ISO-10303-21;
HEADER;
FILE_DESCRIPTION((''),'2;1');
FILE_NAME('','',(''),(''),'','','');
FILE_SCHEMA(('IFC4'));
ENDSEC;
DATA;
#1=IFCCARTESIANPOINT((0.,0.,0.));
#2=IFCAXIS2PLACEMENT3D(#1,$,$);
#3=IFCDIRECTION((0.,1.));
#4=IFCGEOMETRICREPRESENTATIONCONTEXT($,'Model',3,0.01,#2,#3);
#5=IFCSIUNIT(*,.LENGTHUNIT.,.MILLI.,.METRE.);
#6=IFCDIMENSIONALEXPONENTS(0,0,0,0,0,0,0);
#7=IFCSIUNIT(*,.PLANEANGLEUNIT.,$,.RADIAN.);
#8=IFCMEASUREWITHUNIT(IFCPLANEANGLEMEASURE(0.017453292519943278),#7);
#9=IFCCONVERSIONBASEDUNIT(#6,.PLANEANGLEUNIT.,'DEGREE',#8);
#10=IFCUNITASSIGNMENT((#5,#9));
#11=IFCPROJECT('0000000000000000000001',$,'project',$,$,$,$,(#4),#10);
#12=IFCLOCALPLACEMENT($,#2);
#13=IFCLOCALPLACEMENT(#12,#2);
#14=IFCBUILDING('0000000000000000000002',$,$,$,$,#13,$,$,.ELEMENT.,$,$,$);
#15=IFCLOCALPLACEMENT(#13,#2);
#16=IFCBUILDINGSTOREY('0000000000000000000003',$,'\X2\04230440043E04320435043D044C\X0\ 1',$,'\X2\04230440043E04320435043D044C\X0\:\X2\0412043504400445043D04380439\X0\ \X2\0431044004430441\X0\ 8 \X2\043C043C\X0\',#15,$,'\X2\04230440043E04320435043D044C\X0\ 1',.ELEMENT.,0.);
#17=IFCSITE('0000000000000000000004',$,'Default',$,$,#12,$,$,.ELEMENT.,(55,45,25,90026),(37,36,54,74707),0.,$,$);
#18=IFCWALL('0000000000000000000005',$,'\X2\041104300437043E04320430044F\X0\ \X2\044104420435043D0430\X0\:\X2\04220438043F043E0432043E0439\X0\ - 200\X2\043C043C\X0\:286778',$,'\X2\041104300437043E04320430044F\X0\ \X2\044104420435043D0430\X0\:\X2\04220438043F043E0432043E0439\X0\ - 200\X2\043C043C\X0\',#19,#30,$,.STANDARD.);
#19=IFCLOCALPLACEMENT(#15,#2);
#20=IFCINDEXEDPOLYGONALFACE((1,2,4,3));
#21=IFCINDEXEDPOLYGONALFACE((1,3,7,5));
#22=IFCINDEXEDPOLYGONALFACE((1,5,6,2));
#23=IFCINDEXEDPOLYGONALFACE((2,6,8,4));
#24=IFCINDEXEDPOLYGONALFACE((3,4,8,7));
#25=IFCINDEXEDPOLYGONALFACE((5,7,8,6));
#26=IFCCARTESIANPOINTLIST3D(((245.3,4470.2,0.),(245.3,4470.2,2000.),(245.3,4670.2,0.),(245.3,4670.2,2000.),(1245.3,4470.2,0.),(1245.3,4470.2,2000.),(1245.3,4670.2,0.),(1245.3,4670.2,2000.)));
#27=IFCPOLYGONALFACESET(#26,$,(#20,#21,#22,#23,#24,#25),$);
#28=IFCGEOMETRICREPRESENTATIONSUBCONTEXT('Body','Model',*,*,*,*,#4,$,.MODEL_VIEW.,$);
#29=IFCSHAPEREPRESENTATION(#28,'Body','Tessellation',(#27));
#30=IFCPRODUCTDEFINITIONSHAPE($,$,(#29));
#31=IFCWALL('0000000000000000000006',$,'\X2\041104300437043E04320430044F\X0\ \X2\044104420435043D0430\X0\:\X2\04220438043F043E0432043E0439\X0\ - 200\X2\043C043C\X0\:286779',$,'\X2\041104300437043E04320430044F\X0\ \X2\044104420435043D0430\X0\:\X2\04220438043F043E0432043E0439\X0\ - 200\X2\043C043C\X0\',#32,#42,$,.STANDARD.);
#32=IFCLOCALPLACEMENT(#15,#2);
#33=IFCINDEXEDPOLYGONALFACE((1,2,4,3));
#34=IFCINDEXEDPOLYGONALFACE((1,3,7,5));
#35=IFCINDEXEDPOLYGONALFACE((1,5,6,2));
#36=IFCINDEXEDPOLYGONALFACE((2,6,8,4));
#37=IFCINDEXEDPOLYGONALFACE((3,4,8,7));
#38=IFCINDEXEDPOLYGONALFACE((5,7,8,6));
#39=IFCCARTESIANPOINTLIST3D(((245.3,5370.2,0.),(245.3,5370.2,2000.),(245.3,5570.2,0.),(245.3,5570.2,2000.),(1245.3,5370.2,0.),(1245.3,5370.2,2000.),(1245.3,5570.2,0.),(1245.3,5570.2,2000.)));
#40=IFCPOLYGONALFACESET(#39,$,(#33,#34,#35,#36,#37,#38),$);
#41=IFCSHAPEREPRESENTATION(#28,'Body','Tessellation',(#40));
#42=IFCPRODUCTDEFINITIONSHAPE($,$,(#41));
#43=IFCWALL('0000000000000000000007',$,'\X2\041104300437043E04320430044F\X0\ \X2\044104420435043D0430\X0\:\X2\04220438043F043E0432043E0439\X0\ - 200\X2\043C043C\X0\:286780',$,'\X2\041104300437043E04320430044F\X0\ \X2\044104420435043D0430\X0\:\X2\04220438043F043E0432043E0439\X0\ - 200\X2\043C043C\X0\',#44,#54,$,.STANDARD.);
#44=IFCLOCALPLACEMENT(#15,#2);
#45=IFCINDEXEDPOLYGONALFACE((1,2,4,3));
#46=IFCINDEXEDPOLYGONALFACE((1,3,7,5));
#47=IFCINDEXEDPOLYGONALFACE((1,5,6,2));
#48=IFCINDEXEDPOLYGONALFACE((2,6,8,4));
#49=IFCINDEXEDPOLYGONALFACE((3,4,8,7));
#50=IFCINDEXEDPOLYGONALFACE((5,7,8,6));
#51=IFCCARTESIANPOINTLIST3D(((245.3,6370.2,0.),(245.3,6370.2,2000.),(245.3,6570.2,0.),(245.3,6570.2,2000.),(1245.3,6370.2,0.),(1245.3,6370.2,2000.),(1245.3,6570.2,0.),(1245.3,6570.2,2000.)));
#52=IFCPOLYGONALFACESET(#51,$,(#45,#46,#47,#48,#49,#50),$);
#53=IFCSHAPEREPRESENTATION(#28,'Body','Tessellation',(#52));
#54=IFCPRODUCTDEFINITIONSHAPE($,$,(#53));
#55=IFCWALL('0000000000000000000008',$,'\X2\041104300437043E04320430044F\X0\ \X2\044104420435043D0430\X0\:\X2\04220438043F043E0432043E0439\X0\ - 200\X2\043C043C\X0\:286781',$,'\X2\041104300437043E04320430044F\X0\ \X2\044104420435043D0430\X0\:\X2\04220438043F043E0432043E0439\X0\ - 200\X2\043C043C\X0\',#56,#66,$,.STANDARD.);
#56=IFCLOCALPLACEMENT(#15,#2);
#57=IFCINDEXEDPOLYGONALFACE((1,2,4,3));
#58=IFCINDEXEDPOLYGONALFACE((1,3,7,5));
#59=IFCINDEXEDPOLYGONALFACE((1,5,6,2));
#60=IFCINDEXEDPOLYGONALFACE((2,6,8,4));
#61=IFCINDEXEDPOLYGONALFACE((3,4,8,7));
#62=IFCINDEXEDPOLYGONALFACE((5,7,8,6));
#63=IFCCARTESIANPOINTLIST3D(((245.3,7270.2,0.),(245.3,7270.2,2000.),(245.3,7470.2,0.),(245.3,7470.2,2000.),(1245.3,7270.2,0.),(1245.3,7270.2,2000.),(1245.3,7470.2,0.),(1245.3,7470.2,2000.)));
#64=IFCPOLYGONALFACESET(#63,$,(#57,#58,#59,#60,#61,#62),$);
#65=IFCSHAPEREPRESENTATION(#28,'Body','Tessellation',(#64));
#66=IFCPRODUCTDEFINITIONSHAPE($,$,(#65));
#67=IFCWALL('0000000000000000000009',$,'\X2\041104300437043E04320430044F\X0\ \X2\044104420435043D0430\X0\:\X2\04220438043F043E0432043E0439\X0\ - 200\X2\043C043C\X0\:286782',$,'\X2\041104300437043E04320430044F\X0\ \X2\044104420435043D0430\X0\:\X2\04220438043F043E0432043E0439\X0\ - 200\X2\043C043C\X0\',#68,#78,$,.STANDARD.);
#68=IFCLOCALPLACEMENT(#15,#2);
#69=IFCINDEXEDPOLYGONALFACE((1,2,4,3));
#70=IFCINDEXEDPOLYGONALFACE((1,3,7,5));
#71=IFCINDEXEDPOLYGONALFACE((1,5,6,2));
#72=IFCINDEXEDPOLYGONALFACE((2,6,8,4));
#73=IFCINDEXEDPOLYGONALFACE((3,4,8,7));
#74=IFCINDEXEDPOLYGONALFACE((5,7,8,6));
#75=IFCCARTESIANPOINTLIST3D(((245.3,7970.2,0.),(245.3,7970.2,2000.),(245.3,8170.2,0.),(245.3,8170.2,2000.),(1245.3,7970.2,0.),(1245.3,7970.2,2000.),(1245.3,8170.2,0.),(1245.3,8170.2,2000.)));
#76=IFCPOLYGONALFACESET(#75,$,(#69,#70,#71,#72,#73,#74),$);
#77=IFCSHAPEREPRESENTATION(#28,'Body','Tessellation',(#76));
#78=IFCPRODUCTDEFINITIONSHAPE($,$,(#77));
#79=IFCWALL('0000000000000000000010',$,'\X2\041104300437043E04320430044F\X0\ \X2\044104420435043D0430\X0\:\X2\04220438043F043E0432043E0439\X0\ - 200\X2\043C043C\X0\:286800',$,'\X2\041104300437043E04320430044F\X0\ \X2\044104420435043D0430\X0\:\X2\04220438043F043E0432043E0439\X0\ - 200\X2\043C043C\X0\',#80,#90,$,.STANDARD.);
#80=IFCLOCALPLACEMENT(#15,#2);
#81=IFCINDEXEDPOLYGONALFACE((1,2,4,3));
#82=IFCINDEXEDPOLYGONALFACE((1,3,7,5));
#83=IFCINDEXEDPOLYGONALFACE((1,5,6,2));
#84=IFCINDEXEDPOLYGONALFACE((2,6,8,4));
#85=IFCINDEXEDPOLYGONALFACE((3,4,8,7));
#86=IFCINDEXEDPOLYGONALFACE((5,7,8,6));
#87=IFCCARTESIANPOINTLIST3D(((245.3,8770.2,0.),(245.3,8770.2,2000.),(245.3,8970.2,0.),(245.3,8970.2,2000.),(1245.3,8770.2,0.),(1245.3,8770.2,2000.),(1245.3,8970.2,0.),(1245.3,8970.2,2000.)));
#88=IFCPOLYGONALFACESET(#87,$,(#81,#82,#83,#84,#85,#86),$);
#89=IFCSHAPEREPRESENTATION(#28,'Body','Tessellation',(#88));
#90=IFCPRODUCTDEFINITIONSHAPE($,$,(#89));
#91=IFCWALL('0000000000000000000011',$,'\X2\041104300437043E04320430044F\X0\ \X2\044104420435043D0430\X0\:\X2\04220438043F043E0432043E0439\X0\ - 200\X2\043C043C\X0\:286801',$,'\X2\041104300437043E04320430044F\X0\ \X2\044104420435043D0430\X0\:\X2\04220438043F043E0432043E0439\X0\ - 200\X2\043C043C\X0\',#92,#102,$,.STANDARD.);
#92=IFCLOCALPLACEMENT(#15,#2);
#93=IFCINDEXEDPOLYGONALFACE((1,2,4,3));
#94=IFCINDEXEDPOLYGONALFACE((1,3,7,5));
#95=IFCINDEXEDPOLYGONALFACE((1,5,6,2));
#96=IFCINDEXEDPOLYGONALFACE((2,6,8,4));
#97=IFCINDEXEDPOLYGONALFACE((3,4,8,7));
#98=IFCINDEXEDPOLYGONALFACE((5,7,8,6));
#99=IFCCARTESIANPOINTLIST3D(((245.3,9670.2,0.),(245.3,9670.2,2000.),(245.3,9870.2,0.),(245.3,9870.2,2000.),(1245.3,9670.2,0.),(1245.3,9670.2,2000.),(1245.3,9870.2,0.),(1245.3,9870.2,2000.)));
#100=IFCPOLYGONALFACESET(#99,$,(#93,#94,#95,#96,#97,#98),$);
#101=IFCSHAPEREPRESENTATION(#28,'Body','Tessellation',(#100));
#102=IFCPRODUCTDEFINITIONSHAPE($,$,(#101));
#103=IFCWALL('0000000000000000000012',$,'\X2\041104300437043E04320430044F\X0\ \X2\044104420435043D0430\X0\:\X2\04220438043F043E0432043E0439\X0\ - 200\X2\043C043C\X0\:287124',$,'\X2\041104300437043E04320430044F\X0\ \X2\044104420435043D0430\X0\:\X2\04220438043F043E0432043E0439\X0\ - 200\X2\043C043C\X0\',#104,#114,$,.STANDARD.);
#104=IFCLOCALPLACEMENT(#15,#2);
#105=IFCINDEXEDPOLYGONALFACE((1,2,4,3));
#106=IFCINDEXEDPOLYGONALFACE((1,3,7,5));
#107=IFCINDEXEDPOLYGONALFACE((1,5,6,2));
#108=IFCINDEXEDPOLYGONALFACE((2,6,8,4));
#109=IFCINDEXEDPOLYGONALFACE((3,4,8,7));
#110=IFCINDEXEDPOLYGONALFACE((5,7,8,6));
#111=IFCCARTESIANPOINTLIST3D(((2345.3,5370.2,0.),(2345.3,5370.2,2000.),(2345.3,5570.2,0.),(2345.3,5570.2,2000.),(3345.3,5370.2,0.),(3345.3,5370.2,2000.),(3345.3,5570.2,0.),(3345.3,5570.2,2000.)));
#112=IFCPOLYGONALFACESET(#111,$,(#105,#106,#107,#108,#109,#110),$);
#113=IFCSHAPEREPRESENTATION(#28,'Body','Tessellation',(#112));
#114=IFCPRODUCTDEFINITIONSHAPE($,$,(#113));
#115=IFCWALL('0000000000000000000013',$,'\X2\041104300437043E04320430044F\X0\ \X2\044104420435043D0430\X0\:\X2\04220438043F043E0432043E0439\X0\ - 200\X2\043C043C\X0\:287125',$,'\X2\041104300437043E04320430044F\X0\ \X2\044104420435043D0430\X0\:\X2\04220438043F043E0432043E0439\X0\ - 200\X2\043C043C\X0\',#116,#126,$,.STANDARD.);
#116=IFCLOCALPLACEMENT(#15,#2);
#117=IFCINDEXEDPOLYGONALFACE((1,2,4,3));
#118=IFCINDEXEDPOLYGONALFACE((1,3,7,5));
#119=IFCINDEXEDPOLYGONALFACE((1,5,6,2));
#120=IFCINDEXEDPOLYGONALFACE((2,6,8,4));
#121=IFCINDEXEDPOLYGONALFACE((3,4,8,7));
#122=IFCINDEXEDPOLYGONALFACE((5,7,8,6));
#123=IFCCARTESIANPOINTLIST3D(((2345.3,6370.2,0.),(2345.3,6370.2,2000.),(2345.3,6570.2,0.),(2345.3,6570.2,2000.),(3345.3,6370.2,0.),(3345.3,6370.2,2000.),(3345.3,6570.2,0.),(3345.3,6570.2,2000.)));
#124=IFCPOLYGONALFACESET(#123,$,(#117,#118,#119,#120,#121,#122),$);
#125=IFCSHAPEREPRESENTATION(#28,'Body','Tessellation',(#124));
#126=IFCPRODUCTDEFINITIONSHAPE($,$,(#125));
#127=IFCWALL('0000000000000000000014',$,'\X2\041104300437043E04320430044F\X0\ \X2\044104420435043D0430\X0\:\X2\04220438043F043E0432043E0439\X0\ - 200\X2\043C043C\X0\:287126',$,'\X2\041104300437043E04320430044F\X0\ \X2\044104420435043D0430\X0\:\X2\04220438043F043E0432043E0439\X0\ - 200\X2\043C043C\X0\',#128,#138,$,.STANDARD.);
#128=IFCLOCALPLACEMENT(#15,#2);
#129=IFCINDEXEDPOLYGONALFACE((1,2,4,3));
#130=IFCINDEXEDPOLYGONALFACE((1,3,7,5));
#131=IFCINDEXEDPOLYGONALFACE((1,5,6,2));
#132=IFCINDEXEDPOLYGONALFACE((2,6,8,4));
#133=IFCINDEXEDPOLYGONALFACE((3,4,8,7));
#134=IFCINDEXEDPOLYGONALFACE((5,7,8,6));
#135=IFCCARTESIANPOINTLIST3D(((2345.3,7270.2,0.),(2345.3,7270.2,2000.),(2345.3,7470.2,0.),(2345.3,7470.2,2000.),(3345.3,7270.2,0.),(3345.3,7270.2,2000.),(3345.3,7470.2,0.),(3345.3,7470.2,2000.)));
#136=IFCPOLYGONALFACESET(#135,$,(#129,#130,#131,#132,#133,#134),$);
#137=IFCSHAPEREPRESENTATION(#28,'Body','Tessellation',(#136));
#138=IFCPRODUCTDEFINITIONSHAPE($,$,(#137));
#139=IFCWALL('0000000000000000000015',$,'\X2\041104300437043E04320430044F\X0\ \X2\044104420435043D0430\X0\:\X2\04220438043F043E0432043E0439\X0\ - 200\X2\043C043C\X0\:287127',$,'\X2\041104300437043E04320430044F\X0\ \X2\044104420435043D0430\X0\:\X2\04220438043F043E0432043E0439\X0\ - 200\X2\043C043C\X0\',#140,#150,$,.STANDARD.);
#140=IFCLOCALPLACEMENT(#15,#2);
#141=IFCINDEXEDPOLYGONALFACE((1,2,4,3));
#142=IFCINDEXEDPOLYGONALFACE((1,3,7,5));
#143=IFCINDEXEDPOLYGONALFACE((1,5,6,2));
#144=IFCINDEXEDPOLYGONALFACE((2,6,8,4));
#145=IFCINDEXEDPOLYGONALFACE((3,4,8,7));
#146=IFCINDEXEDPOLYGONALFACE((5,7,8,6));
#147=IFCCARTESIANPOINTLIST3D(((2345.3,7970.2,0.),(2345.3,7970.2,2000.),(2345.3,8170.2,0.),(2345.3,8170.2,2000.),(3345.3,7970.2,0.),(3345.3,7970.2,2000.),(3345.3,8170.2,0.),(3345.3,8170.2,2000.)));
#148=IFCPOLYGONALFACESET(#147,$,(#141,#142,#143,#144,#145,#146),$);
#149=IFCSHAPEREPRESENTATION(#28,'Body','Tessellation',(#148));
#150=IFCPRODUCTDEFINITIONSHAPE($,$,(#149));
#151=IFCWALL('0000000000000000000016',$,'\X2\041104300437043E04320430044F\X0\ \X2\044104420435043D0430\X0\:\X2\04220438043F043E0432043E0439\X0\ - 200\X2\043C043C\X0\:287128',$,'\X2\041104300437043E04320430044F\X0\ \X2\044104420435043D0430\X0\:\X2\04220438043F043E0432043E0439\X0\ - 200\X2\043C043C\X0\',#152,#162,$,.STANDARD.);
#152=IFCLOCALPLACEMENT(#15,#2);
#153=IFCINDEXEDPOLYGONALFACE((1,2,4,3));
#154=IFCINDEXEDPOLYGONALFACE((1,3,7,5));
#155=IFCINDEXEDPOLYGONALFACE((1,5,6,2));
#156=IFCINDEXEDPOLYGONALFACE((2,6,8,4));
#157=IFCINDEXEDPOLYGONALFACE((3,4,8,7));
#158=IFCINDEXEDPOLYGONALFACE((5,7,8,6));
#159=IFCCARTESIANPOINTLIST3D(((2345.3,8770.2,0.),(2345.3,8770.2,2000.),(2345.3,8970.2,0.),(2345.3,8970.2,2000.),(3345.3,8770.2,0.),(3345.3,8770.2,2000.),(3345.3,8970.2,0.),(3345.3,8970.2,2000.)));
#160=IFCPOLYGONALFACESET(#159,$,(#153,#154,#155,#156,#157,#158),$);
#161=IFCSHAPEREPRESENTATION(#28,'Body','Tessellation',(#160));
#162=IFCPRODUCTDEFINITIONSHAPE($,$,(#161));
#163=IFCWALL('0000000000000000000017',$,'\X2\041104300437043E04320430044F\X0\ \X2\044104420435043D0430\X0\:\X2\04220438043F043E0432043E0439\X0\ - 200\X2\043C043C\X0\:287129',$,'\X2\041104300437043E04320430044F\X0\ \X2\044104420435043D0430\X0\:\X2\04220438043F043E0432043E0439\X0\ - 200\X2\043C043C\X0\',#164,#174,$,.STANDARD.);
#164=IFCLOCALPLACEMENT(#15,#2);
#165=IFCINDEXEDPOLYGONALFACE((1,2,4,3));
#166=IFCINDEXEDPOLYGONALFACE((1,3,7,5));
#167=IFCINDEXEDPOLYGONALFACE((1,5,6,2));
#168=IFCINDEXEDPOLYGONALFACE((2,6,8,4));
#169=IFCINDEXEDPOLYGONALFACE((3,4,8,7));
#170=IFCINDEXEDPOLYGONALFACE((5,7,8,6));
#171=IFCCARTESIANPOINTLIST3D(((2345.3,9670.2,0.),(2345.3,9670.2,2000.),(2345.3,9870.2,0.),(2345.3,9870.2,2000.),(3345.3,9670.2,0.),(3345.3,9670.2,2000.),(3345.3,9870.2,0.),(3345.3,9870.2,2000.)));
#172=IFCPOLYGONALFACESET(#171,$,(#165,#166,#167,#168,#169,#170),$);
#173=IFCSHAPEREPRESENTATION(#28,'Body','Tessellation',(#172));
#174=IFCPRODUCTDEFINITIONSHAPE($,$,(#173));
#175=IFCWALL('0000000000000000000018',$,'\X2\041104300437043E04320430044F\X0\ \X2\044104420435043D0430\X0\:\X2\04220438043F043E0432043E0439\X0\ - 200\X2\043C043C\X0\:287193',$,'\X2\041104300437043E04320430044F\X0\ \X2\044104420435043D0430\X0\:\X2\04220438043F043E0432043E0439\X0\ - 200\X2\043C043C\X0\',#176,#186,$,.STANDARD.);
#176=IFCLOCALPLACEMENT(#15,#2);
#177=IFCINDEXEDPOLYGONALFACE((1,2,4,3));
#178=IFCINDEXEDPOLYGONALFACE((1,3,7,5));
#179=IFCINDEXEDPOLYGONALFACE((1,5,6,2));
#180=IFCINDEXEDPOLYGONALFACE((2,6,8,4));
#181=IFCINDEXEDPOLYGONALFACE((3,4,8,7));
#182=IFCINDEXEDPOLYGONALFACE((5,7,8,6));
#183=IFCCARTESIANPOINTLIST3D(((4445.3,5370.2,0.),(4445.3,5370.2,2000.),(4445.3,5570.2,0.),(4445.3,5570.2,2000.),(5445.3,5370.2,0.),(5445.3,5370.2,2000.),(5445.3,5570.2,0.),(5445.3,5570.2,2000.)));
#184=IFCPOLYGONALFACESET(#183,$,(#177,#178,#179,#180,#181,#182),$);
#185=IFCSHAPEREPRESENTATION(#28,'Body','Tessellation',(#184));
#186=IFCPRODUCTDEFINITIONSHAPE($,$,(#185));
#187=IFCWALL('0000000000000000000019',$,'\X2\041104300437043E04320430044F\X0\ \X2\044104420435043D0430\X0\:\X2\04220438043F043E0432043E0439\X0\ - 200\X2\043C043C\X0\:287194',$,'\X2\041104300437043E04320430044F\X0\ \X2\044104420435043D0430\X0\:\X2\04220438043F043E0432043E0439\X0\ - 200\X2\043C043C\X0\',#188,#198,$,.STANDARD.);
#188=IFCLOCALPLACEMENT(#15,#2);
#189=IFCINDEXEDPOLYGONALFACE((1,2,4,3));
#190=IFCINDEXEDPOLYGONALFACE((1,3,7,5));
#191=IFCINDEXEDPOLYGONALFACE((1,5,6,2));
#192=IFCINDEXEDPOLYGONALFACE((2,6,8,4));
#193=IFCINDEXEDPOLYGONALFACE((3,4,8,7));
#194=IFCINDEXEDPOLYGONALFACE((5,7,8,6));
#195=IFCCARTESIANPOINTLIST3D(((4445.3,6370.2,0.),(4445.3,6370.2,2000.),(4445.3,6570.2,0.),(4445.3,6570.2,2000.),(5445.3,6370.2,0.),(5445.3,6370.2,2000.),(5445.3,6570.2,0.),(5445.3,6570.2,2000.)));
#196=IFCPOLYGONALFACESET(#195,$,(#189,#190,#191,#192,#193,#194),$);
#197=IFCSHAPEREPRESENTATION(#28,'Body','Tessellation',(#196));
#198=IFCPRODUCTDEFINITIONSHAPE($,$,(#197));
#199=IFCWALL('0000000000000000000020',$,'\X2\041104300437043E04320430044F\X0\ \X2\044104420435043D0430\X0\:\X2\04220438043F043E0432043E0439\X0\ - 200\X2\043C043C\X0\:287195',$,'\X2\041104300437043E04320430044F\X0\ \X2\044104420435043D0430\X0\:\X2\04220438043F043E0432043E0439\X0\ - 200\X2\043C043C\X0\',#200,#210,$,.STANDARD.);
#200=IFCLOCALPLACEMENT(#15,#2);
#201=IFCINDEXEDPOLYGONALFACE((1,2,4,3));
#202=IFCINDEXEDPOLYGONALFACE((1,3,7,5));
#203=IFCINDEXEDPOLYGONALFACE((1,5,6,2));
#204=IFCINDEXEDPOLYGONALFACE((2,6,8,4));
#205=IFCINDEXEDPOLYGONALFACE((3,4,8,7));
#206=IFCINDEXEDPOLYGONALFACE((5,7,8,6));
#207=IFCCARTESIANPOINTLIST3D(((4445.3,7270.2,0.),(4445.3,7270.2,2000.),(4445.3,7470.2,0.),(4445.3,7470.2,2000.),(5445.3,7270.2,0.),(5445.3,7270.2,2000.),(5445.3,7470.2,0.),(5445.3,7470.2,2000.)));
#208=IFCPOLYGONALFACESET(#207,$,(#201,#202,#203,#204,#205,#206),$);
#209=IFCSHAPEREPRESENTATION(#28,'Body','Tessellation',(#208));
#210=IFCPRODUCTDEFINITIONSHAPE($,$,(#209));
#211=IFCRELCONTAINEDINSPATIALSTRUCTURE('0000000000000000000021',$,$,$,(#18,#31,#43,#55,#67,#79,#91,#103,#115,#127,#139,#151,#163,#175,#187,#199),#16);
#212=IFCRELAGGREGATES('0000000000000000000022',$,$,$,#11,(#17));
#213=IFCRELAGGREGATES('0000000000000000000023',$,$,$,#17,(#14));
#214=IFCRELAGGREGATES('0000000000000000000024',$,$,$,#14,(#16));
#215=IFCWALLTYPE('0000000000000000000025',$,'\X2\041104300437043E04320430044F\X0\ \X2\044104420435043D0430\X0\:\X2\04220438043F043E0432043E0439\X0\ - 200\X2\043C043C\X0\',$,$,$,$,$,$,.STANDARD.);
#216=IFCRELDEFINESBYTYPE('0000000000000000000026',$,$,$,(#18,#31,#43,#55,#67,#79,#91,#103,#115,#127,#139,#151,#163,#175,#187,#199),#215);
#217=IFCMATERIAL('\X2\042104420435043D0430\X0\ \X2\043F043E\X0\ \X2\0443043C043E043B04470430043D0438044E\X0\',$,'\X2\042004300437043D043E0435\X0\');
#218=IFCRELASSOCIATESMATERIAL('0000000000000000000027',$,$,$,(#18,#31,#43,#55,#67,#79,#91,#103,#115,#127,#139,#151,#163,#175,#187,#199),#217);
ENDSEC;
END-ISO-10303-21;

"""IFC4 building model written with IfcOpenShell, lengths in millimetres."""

from ifc_helpers import new_model, entity, si_unit, converted_unit, direction, frame, origin, place, context, subcontext, project, spatial, indexed_curve, outline, extrude, material, type_object, element, save


model = new_model("IFC4")

# Units and contexts
model_context = context("Model", 3, precision=0.01, world=origin(), true_north=direction((0.0, 1.0)))
body_context = subcontext(model_context, "Body", "Model", "MODEL_VIEW")
ifc_project = project(units=[si_unit("LENGTHUNIT", "METRE", prefix="MILLI"), converted_unit("PLANEANGLEUNIT", "DEGREE", entity("IfcPlaneAngleMeasure", 0.017453292519943278), si_unit("PLANEANGLEUNIT", "RADIAN"), dimensions=[0, 0, 0, 0, 0, 0, 0])], contexts=[model_context])

# Site, building, storey
site_placement = place(None, origin())
site = spatial("IfcSite", under=ifc_project, at=site_placement, Name="Default", CompositionType="ELEMENT", RefLatitude=(55, 45, 25, 90026), RefLongitude=(37, 36, 54, 74707), RefElevation=0.0)
building_placement = place(site_placement, origin())
building = spatial("IfcBuilding", under=site, at=building_placement, CompositionType="ELEMENT")
storey_placement = place(building_placement, origin())
storey = spatial("IfcBuildingStorey", under=building, at=storey_placement, Name="Уровень 1", ObjectType="Уровень:Верхний брус 8 мм", LongName="Уровень 1", CompositionType="ELEMENT", Elevation=0.0)

# Walls
ifc_material = material(Name="Стена по умолчанию", Category="Разное")
wall_type = type_object("IfcWallType", Name="Базовая стена:Типовой - 200мм", PredefinedType="STANDARD")
for number, where, name in (
    (1, (245.3, 4570.2, 0.0), "Базовая стена:Типовой - 200мм:286778"),
    (2, (245.3, 5470.2, 0.0), "Базовая стена:Типовой - 200мм:286779"),
    (3, (245.3, 6470.2, 0.0), "Базовая стена:Типовой - 200мм:286780"),
):
    element("IfcWall", number, at=place(storey_placement, frame(where)), inside=storey, type_object=wall_type, material=ifc_material, Name=name, ObjectType="Базовая стена:Типовой - 200мм", PredefinedType="STANDARD", context=body_context, shape_type="SweptSolid", body=[
        extrude(outline(indexed_curve([(1000.0, 100.0), (0.0, 100.0), (0.0, -100.0), (1000.0, -100.0), (1000.0, 100.0)], self_intersect=False)), origin(), (0.0, 0.0, 1.0), 2000.0),
    ])
for number, where, name in (
    (4, (245.3, 7370.2, 0.0), "Базовая стена:Типовой - 200мм:286781"),
    (5, (245.3, 8070.2, 0.0), "Базовая стена:Типовой - 200мм:286782"),
):
    element("IfcWall", number, at=place(storey_placement, frame(where)), inside=storey, type_object=wall_type, material=ifc_material, Name=name, ObjectType="Базовая стена:Типовой - 200мм", PredefinedType="STANDARD", context=body_context, shape_type="SweptSolid", body=[
        extrude(outline(indexed_curve([(1000.0, 100.0), (0.0, 100.0), (0.0, -100.0), (1000.0, -100.0), (1000.0, 100.0)], self_intersect=False)), origin(), (0.0, 0.0, 1.0), 2000.0),
    ])
wall_1_placement = place(storey_placement, frame((245.3, 8870.2, 0.0)))
element("IfcWall", 6, at=wall_1_placement, inside=storey, type_object=wall_type, material=ifc_material, Name="Базовая стена:Типовой - 200мм:286800", ObjectType="Базовая стена:Типовой - 200мм", PredefinedType="STANDARD", context=body_context, shape_type="SweptSolid", body=[
    extrude(outline(indexed_curve([(1000.0, 100.0), (0.0, 100.0), (0.0, -100.0), (1000.0, -100.0), (1000.0, 100.0)], self_intersect=False)), origin(), (0.0, 0.0, 1.0), 2000.0),
])
wall_2_placement = place(storey_placement, frame((245.3, 9770.2, 0.0)))
element("IfcWall", 7, at=wall_2_placement, inside=storey, type_object=wall_type, material=ifc_material, Name="Базовая стена:Типовой - 200мм:286801", ObjectType="Базовая стена:Типовой - 200мм", PredefinedType="STANDARD", context=body_context, shape_type="SweptSolid", body=[
    extrude(outline(indexed_curve([(1000.0, 100.0), (0.0, 100.0), (0.0, -100.0), (1000.0, -100.0), (1000.0, 100.0)], self_intersect=False)), origin(), (0.0, 0.0, 1.0), 2000.0),
])
for number, where, name in (
    (8, (2345.3, 5470.2, 0.0), "Базовая стена:Типовой - 200мм:287124"),
    (9, (2345.3, 6470.2, 0.0), "Базовая стена:Типовой - 200мм:287125"),
):
    element("IfcWall", number, at=place(storey_placement, frame(where)), inside=storey, type_object=wall_type, material=ifc_material, Name=name, ObjectType="Базовая стена:Типовой - 200мм", PredefinedType="STANDARD", context=body_context, shape_type="SweptSolid", body=[
        extrude(outline(indexed_curve([(1000.0, 100.0), (0.0, 100.0), (0.0, -100.0), (1000.0, -100.0), (1000.0, 100.0)], self_intersect=False)), origin(), (0.0, 0.0, 1.0), 2000.0),
    ])
for number, where, name in (
    (10, (2345.3, 7370.2, 0.0), "Базовая стена:Типовой - 200мм:287126"),
    (11, (2345.3, 8070.2, 0.0), "Базовая стена:Типовой - 200мм:287127"),
):
    element("IfcWall", number, at=place(storey_placement, frame(where)), inside=storey, type_object=wall_type, material=ifc_material, Name=name, ObjectType="Базовая стена:Типовой - 200мм", PredefinedType="STANDARD", context=body_context, shape_type="SweptSolid", body=[
        extrude(outline(indexed_curve([(1000.0, 100.0), (0.0, 100.0), (0.0, -100.0), (1000.0, -100.0), (1000.0, 100.0)], self_intersect=False)), origin(), (0.0, 0.0, 1.0), 2000.0),
    ])
wall_3_placement = place(storey_placement, frame((2345.3, 8870.2, 0.0)))
element("IfcWall", 12, at=wall_3_placement, inside=storey, type_object=wall_type, material=ifc_material, Name="Базовая стена:Типовой - 200мм:287128", ObjectType="Базовая стена:Типовой - 200мм", PredefinedType="STANDARD", context=body_context, shape_type="SweptSolid", body=[
    extrude(outline(indexed_curve([(1000.0, 100.0), (0.0, 100.0), (0.0, -100.0), (1000.0, -100.0), (1000.0, 100.0)], self_intersect=False)), origin(), (0.0, 0.0, 1.0), 2000.0),
])
wall_4_placement = place(storey_placement, frame((2345.3, 9770.2, 0.0)))
element("IfcWall", 13, at=wall_4_placement, inside=storey, type_object=wall_type, material=ifc_material, Name="Базовая стена:Типовой - 200мм:287129", ObjectType="Базовая стена:Типовой - 200мм", PredefinedType="STANDARD", context=body_context, shape_type="SweptSolid", body=[
    extrude(outline(indexed_curve([(1000.0, 100.0), (0.0, 100.0), (0.0, -100.0), (1000.0, -100.0), (1000.0, 100.0)], self_intersect=False)), origin(), (0.0, 0.0, 1.0), 2000.0),
])
for number, where, name in (
    (14, (4445.3, 5470.2, 0.0), "Базовая стена:Типовой - 200мм:287193"),
    (15, (4445.3, 6470.2, 0.0), "Базовая стена:Типовой - 200мм:287194"),
):
    element("IfcWall", number, at=place(storey_placement, frame(where)), inside=storey, type_object=wall_type, material=ifc_material, Name=name, ObjectType="Базовая стена:Типовой - 200мм", PredefinedType="STANDARD", context=body_context, shape_type="SweptSolid", body=[
        extrude(outline(indexed_curve([(1000.0, 100.0), (0.0, 100.0), (0.0, -100.0), (1000.0, -100.0), (1000.0, 100.0)], self_intersect=False)), origin(), (0.0, 0.0, 1.0), 2000.0),
    ])
for number, where, name in (
    (16, (4445.3, 7370.2, 0.0), "Базовая стена:Типовой - 200мм:287195"),
):
    element("IfcWall", number, at=place(storey_placement, frame(where)), inside=storey, type_object=wall_type, material=ifc_material, Name=name, ObjectType="Базовая стена:Типовой - 200мм", PredefinedType="STANDARD", context=body_context, shape_type="SweptSolid", body=[
        extrude(outline(indexed_curve([(1000.0, 100.0), (0.0, 100.0), (0.0, -100.0), (1000.0, -100.0), (1000.0, 100.0)], self_intersect=False)), origin(), (0.0, 0.0, 1.0), 2000.0),
    ])

save(model, "model.ifc")
